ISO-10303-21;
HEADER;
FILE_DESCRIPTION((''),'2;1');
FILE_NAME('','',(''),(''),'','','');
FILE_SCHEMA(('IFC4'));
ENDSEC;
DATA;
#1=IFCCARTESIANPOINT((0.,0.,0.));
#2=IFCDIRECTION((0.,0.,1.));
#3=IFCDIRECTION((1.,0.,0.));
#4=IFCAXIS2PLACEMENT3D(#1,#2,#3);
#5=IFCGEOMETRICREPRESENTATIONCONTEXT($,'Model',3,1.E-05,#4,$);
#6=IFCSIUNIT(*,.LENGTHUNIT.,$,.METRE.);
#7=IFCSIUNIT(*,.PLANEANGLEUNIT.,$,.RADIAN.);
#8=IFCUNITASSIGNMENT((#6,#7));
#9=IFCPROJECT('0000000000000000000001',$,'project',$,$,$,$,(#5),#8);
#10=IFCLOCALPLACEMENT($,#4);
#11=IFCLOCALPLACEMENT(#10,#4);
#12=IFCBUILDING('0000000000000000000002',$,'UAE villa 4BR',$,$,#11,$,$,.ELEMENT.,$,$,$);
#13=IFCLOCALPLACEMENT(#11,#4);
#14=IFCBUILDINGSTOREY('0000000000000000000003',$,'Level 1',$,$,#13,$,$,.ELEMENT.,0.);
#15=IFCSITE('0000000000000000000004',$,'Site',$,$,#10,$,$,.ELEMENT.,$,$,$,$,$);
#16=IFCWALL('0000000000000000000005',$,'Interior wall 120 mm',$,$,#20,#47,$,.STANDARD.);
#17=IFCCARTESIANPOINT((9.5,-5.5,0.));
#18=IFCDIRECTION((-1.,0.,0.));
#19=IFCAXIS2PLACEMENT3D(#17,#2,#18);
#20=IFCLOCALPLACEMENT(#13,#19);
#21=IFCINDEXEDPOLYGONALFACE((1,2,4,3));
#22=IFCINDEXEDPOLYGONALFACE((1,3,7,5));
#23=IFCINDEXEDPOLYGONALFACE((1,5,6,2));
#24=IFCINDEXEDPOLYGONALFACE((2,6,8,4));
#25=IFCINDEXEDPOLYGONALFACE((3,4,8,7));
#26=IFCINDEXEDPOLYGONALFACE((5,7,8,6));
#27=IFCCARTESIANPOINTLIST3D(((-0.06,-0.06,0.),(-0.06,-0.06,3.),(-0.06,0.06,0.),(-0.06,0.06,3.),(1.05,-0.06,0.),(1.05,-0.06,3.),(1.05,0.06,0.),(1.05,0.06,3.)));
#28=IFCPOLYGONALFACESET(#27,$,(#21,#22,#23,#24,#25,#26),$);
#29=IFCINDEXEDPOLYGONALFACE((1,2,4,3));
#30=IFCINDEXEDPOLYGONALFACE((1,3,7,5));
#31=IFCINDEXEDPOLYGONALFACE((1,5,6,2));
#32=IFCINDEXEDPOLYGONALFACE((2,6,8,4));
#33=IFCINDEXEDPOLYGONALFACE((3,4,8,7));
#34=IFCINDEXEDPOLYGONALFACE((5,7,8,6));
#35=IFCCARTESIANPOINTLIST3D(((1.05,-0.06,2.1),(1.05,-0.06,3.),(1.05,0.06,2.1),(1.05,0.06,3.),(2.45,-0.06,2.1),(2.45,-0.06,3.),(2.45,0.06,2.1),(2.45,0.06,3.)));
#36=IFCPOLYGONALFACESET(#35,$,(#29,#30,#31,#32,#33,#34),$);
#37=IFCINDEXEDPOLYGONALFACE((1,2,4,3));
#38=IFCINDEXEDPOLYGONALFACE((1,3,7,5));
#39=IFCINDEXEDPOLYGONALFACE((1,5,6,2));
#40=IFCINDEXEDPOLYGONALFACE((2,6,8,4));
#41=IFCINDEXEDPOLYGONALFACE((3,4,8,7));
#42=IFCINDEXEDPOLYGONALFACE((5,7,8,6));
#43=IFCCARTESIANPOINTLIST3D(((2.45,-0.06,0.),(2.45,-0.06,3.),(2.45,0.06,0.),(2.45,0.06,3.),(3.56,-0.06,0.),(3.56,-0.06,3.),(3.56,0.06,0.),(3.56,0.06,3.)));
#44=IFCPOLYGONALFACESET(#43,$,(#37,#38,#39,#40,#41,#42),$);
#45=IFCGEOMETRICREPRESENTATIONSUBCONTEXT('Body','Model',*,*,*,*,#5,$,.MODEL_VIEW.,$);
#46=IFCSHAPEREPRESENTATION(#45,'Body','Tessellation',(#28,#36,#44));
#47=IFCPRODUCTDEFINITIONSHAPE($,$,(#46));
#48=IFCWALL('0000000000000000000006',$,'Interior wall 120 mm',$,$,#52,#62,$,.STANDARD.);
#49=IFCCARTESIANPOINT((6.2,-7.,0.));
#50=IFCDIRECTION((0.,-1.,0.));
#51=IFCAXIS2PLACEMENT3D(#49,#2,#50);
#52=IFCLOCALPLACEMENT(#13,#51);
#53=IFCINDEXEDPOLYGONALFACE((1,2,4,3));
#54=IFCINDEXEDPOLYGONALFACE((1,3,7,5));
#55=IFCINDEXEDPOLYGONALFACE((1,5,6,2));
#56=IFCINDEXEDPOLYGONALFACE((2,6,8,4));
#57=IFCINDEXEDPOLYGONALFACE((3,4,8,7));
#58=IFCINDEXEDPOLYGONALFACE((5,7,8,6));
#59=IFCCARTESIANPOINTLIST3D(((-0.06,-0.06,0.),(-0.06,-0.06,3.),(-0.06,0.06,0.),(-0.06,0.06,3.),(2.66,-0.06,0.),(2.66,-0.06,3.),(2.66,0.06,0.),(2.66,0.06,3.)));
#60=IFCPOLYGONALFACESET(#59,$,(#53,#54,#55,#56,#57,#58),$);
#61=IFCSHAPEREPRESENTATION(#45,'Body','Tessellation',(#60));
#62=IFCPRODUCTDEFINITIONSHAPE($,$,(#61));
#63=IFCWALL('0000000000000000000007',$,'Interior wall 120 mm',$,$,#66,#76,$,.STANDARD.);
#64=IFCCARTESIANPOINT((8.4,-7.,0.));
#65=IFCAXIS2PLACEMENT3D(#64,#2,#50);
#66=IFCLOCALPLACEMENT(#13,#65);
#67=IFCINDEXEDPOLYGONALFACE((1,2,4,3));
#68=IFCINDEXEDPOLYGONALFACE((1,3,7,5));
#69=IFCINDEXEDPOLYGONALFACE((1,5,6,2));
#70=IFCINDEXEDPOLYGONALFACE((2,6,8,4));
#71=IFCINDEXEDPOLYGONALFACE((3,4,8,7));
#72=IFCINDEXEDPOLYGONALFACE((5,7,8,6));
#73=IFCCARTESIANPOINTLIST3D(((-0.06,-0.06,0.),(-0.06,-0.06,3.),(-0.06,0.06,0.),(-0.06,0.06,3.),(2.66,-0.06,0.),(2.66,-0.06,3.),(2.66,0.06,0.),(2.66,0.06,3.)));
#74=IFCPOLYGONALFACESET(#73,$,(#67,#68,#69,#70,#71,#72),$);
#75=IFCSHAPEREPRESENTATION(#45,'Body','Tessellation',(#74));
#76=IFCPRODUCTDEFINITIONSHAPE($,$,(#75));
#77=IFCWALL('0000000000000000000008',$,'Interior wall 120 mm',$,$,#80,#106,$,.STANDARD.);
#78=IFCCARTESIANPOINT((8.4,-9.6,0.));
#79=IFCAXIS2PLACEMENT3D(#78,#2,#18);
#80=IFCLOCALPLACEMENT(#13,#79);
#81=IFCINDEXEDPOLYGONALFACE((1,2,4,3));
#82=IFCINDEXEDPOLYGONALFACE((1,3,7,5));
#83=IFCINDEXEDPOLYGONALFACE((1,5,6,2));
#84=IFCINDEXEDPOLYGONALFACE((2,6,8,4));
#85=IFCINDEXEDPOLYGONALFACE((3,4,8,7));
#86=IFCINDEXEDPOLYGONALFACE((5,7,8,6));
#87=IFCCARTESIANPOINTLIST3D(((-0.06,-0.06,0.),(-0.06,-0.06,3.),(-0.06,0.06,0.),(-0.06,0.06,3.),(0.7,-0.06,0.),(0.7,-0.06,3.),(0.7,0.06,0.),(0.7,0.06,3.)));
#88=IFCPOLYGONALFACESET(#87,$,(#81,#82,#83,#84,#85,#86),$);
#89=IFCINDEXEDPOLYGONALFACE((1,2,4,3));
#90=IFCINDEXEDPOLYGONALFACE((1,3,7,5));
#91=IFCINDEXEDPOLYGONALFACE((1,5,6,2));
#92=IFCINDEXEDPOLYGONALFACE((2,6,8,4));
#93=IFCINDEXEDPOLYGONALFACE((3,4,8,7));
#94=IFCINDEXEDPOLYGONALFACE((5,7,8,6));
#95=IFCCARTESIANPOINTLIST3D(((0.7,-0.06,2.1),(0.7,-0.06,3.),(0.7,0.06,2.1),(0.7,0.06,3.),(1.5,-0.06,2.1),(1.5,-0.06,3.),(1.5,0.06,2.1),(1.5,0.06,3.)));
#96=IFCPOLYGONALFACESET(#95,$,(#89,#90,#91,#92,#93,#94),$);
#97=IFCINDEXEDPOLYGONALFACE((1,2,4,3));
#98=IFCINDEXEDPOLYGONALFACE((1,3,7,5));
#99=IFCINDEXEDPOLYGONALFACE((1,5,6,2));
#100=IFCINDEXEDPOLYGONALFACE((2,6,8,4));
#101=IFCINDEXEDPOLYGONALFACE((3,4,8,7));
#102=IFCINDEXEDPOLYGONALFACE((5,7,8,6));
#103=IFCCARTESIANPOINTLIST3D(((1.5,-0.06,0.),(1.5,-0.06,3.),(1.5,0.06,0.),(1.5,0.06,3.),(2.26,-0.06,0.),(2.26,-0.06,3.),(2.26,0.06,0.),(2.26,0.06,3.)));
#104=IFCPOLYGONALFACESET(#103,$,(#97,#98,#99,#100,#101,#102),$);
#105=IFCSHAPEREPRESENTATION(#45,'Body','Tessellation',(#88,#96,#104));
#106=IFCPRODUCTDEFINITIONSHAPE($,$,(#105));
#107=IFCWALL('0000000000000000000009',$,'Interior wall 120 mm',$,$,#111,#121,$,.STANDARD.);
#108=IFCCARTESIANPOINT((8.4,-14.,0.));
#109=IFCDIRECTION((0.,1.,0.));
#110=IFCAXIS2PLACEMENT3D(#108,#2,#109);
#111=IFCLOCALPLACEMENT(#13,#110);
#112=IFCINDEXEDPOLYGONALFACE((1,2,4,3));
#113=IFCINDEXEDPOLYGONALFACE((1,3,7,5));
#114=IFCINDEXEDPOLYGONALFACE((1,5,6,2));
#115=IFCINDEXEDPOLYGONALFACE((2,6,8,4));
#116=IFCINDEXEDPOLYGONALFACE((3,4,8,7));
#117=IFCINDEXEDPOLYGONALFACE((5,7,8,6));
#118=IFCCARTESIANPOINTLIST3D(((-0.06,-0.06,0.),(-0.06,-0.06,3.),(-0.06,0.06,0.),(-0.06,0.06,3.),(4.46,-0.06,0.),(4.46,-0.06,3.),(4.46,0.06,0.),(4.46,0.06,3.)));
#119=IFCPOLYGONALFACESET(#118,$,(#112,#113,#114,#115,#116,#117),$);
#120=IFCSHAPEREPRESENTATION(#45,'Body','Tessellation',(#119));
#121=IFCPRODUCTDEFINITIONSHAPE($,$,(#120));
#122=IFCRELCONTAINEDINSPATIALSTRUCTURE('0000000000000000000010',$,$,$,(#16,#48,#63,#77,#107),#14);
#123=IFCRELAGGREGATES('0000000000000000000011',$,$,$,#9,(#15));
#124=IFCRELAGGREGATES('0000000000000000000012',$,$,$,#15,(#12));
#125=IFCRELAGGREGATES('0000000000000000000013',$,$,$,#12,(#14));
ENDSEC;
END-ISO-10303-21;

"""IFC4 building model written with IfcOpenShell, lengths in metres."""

from ifc_helpers import new_model, si_unit, frame, origin_with_axes, origin_2d, place, context, subcontext, project, spatial, rectangle, extrude, element, save


model = new_model("IFC4")

# Units and contexts
model_context = context("Model", 3, precision=1e-05, world=origin_with_axes())
body_context = subcontext(model_context, "Body", "Model", "MODEL_VIEW")
ifc_project = project(units=[si_unit("LENGTHUNIT", "METRE"), si_unit("PLANEANGLEUNIT", "RADIAN")], contexts=[model_context])

# Site, building, storey
site_placement = place(None, origin_with_axes())
site = spatial("IfcSite", under=ifc_project, at=site_placement, Name="Site", CompositionType="ELEMENT")
building_placement = place(site_placement, origin_with_axes())
building = spatial("IfcBuilding", under=site, at=building_placement, Name="UAE villa 4BR", CompositionType="ELEMENT")
storey_placement = place(building_placement, origin_with_axes())
storey = spatial("IfcBuildingStorey", under=building, at=storey_placement, Name="Level 1", CompositionType="ELEMENT", Elevation=0.0)

# Walls
wall_1_placement = place(storey_placement, frame((9.5, -5.5, 0.0), z_axis=(0.0, 0.0, 1.0), x_axis=(-1.0, 0.0, 0.0)))
element("IfcWall", 1, at=wall_1_placement, inside=storey, Name="Interior wall 120 mm", PredefinedType="STANDARD", context=body_context, shape_type="SweptSolid", body=[
    extrude(rectangle(XDim=1.11, YDim=0.12, at=origin_2d()), frame((0.495, 0.0, 0.0)), (0.0, 0.0, 1.0), 3.0),
    extrude(rectangle(XDim=1.4, YDim=0.12, at=origin_2d()), frame((1.75, 0.0, 2.1)), (0.0, 0.0, 1.0), 0.9),
    extrude(rectangle(XDim=1.11, YDim=0.12, at=origin_2d()), frame((3.005, 0.0, 0.0)), (0.0, 0.0, 1.0), 3.0),
])
wall_2_placement = place(storey_placement, frame((6.2, -7.0, 0.0), z_axis=(0.0, 0.0, 1.0), x_axis=(0.0, -1.0, 0.0)))
element("IfcWall", 2, at=wall_2_placement, inside=storey, Name="Interior wall 120 mm", PredefinedType="STANDARD", context=body_context, shape_type="SweptSolid", body=[
    extrude(rectangle(XDim=2.72, YDim=0.12, at=origin_2d()), frame((1.3, 0.0, 0.0)), (0.0, 0.0, 1.0), 3.0),
])
wall_3_placement = place(storey_placement, frame((8.4, -7.0, 0.0), z_axis=(0.0, 0.0, 1.0), x_axis=(0.0, -1.0, 0.0)))
element("IfcWall", 3, at=wall_3_placement, inside=storey, Name="Interior wall 120 mm", PredefinedType="STANDARD", context=body_context, shape_type="SweptSolid", body=[
    extrude(rectangle(XDim=2.72, YDim=0.12, at=origin_2d()), frame((1.3, 0.0, 0.0)), (0.0, 0.0, 1.0), 3.0),
])
wall_4_placement = place(storey_placement, frame((8.4, -9.6, 0.0), z_axis=(0.0, 0.0, 1.0), x_axis=(-1.0, 0.0, 0.0)))
element("IfcWall", 4, at=wall_4_placement, inside=storey, Name="Interior wall 120 mm", PredefinedType="STANDARD", context=body_context, shape_type="SweptSolid", body=[
    extrude(rectangle(XDim=0.76, YDim=0.12, at=origin_2d()), frame((0.32, 0.0, 0.0)), (0.0, 0.0, 1.0), 3.0),
    extrude(rectangle(XDim=0.8, YDim=0.12, at=origin_2d()), frame((1.1, 0.0, 2.1)), (0.0, 0.0, 1.0), 0.9),
    extrude(rectangle(XDim=0.76, YDim=0.12, at=origin_2d()), frame((1.88, 0.0, 0.0)), (0.0, 0.0, 1.0), 3.0),
])
wall_5_placement = place(storey_placement, frame((8.4, -14.0, 0.0), z_axis=(0.0, 0.0, 1.0), x_axis=(0.0, 1.0, 0.0)))
element("IfcWall", 5, at=wall_5_placement, inside=storey, Name="Interior wall 120 mm", PredefinedType="STANDARD", context=body_context, shape_type="SweptSolid", body=[
    extrude(rectangle(XDim=4.52, YDim=0.12, at=origin_2d()), frame((2.2, 0.0, 0.0)), (0.0, 0.0, 1.0), 3.0),
])

save(model, "model.ifc")
